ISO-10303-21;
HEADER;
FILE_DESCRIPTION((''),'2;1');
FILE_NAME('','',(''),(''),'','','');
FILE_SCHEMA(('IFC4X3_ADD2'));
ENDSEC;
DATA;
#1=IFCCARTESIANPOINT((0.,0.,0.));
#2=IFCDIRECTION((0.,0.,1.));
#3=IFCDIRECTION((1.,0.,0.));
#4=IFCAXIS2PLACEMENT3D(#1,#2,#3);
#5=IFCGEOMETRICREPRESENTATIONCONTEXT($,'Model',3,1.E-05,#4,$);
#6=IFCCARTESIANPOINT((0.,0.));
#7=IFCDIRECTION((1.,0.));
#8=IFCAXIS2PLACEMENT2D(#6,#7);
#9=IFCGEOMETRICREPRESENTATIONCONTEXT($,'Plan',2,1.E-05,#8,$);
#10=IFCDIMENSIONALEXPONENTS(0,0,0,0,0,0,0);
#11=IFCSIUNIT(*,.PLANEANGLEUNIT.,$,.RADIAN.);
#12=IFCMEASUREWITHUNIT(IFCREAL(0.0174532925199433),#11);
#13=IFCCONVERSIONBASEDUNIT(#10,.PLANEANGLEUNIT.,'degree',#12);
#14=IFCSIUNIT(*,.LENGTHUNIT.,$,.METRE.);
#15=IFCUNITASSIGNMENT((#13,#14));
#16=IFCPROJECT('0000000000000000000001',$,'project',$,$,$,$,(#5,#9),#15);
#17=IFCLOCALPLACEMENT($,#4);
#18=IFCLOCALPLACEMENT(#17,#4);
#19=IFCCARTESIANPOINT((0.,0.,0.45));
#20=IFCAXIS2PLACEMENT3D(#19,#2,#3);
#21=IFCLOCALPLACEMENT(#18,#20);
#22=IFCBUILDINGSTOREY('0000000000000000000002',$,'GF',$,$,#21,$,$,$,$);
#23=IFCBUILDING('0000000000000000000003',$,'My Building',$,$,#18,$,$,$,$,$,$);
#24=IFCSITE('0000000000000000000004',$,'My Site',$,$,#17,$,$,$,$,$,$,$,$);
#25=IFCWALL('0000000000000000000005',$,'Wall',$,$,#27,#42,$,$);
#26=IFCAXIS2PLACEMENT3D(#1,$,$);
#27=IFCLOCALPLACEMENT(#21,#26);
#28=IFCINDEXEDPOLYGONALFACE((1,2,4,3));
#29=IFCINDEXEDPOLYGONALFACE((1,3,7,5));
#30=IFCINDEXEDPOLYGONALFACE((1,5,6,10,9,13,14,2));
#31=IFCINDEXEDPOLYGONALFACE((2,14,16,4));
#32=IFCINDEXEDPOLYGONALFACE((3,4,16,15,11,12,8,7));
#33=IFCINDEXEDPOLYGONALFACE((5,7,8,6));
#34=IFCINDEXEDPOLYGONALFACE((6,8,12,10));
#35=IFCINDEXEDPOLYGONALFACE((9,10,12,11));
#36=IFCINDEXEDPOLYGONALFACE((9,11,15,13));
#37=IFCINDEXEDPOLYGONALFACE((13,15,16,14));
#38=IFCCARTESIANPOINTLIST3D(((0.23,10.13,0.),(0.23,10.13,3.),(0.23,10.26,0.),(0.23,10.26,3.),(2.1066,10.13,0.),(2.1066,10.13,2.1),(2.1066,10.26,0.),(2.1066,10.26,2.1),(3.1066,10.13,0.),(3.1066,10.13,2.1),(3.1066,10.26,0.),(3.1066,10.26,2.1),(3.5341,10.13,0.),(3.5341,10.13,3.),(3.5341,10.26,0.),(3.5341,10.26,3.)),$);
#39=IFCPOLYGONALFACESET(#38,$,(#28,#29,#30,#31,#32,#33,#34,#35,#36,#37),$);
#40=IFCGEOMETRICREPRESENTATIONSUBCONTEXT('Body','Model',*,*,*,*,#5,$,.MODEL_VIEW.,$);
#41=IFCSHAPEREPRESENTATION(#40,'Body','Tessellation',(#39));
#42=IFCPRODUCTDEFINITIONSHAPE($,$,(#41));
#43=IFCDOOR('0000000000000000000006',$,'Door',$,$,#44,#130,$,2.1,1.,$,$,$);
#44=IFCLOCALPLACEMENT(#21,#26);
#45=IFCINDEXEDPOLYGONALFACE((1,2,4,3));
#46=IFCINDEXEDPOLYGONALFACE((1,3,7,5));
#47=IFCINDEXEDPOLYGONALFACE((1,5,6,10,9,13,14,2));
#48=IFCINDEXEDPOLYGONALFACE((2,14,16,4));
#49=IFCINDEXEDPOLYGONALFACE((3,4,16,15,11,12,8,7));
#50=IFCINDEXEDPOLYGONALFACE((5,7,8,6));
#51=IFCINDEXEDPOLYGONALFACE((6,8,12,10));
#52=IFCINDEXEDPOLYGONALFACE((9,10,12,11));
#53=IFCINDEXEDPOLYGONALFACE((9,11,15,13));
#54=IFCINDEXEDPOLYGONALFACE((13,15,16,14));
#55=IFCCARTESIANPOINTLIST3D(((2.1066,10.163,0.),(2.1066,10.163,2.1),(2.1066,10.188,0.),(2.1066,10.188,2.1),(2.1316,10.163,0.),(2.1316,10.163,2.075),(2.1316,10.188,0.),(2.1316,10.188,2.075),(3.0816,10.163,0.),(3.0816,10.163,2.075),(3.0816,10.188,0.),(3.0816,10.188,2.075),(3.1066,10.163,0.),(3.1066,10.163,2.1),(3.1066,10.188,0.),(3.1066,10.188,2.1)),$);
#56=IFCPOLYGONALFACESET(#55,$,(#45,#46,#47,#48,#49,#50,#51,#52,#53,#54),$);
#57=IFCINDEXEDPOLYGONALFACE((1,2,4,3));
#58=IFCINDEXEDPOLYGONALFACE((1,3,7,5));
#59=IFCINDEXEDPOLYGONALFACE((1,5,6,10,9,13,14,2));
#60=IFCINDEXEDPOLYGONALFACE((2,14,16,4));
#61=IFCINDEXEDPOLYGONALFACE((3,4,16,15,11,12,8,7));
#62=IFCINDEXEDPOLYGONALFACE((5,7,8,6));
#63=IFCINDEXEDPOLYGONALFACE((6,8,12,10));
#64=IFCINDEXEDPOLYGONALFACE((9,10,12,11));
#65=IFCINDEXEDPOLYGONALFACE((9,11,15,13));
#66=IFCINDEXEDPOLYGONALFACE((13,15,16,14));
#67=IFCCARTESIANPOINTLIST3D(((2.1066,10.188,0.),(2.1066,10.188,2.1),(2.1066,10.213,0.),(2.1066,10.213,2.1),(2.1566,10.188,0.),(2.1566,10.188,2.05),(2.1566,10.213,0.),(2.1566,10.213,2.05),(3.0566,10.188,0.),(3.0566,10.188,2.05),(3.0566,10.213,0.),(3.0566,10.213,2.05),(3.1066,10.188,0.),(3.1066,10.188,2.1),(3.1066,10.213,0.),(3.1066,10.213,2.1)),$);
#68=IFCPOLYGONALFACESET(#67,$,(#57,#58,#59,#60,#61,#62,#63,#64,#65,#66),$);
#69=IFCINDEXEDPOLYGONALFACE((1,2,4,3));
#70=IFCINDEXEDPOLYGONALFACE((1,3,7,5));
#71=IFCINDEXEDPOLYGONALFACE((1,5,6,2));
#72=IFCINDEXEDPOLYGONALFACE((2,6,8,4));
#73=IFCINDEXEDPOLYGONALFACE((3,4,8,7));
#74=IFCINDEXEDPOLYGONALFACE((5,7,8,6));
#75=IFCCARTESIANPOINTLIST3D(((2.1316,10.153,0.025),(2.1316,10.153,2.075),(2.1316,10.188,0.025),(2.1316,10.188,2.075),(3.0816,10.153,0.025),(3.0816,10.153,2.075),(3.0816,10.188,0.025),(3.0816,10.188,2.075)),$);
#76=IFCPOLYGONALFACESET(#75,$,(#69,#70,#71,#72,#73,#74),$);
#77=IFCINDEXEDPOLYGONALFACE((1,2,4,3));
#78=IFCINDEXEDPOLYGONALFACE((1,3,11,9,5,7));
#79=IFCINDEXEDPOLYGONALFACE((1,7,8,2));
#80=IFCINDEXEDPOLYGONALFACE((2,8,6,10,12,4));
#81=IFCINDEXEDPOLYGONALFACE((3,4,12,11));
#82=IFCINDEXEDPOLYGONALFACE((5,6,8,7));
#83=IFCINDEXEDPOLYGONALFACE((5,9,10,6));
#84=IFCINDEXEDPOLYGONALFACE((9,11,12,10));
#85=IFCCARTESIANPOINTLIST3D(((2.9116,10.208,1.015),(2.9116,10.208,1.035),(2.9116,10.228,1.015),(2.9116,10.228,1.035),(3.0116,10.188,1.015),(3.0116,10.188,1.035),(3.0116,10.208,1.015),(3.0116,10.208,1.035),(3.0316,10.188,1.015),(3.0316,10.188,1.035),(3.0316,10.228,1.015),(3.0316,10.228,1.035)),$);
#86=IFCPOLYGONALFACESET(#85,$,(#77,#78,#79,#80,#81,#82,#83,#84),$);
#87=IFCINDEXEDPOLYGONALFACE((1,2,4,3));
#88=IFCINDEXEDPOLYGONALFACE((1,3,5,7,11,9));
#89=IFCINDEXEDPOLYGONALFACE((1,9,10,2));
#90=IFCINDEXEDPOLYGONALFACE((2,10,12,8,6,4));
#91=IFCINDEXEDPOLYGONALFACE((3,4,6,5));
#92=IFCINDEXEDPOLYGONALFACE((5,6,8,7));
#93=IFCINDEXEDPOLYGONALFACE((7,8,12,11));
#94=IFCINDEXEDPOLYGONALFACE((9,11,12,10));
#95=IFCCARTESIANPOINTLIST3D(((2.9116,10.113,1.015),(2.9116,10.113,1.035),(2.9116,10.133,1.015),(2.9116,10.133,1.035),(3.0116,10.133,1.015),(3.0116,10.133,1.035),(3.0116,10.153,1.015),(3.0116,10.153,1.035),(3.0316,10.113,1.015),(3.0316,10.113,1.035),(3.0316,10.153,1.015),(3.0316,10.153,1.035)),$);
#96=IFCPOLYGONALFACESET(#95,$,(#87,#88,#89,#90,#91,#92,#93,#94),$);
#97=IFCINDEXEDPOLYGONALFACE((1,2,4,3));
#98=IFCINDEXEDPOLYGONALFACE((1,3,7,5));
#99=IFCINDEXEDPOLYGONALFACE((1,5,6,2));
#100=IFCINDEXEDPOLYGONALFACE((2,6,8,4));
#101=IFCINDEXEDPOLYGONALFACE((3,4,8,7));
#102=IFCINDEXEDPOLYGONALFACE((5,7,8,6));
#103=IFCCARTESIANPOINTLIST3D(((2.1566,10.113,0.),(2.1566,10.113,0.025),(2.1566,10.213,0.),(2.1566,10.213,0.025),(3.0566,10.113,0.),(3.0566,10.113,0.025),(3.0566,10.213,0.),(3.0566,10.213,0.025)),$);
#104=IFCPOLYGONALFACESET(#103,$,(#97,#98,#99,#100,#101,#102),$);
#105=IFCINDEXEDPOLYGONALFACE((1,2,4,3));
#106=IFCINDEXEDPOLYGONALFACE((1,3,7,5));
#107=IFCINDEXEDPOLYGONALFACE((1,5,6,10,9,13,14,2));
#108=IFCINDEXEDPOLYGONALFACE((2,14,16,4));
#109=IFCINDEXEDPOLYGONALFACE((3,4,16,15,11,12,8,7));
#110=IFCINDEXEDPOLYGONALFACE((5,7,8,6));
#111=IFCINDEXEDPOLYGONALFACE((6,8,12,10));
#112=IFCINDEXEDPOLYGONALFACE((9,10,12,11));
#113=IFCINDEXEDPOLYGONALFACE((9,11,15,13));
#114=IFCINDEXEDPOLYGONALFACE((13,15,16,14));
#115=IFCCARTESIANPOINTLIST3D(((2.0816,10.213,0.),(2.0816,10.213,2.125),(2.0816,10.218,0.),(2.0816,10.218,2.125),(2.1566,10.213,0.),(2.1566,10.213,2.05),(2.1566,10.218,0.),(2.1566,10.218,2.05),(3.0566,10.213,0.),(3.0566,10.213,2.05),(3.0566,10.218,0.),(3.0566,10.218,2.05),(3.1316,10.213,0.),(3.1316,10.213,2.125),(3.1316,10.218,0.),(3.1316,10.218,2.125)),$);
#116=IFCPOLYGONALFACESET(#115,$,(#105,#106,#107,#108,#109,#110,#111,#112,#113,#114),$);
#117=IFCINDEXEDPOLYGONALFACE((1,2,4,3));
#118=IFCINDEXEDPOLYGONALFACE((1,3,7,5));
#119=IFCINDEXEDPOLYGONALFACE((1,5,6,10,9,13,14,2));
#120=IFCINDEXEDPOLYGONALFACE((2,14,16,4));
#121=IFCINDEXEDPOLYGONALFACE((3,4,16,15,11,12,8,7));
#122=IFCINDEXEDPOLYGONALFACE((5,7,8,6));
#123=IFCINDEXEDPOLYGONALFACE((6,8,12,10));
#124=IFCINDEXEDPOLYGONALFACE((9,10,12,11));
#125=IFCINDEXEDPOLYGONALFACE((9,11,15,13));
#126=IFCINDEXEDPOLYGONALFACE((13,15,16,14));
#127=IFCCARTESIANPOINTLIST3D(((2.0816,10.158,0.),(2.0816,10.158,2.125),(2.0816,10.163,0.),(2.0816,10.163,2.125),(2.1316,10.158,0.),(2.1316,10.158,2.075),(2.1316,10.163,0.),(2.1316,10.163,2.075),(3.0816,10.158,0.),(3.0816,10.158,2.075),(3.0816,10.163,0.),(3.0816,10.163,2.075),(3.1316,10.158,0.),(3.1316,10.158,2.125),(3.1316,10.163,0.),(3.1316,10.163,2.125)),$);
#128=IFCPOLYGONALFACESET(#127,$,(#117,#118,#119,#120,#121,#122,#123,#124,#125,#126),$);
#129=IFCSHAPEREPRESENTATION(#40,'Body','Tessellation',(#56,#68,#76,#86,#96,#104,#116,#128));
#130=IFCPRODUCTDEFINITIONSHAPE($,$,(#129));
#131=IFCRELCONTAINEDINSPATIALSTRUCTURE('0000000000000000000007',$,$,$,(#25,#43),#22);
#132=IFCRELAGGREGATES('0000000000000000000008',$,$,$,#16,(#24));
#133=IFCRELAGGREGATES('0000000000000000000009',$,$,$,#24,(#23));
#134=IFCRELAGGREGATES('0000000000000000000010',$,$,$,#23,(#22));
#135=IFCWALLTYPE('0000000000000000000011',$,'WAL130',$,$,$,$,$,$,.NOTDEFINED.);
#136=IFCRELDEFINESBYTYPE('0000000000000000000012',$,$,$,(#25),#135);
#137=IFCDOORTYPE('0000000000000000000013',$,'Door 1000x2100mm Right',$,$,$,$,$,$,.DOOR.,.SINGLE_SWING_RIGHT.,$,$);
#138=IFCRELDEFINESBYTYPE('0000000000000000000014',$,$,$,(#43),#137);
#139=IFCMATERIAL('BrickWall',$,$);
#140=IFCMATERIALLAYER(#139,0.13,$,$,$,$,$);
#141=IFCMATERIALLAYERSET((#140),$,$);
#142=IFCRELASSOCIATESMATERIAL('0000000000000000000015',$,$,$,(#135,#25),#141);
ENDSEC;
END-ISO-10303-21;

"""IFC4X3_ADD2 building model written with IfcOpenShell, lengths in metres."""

from ifc_helpers import new_model, entity, si_unit, converted_unit, frame, origin_with_axes, origin_2d_with_axis, place, context, subcontext, project, spatial, line, indexed_curve, outline, extrude, shape, source, transform, mapped, material, layer, layer_set, layer_usage, type_object, type_shapes, element, fill, save


model = new_model("IFC4X3_ADD2")

# Units and contexts
model_context = context("Model", 3, precision=1e-05, world=origin_with_axes())
plan_context = context("Plan", 2, precision=1e-05, world=origin_2d_with_axis())
body_context_1 = subcontext(model_context, "Body", "Model", "MODEL_VIEW")
body_context_2 = subcontext(plan_context, "Body", "Plan", "PLAN_VIEW")
ifc_project = project(units=[converted_unit("PLANEANGLEUNIT", "degree", entity("IfcReal", 0.0174532925199433), si_unit("PLANEANGLEUNIT", "RADIAN"), dimensions=[0, 0, 0, 0, 0, 0, 0]), si_unit("LENGTHUNIT", "METRE")], contexts=[model_context, plan_context])

# Site, building, storey
site_placement = place(None, origin_with_axes())
site = spatial("IfcSite", under=ifc_project, at=site_placement, Name="My Site")
building_placement = place(site_placement, origin_with_axes())
building = spatial("IfcBuilding", under=site, at=building_placement, Name="My Building")
storey_placement = place(building_placement, frame((0.0, 0.0, 0.45), z_axis=(0.0, 0.0, 1.0), x_axis=(1.0, 0.0, 0.0)))
storey = spatial("IfcBuildingStorey", under=building, at=storey_placement, Name="GF")

# Shared definitions
ifc_material = material(Name="BrickWall")

# Wall, opening, door
ifc_layer_1 = layer(ifc_material, 0.13)
ifc_layer_set_1 = layer_set([ifc_layer_1])
ifc_layer_usage_1 = layer_usage(ifc_layer_set_1, "AXIS2", "POSITIVE", 0.0)
wall_type_1 = type_object("IfcWallType", Name="WAL130", PredefinedType="NOTDEFINED", material=ifc_layer_set_1)
wall_1_placement = place(storey_placement, frame((0.23, 10.13, 0.0), z_axis=(0.0, 0.0, 1.0), x_axis=(1.0, 0.0, 0.0)))
wall_1 = element("IfcWall", 1, at=wall_1_placement, inside=storey, type_object=wall_type_1, material=ifc_layer_usage_1, Name="Wall", context=body_context_1, shape_type="SweptSolid", body=[
    extrude(outline(indexed_curve([(0.0, 0.0), (0.0, 0.13), (3.3041, 0.13), (3.3041, 0.0), (0.0, 0.0)], self_intersect=False)), origin_with_axes(), (0.0, 0.0, 1.0), 3.0),
])
shared_shape_1 = source(origin_with_axes(), body_context_1, "Body", "SweptSolid", [
    extrude(outline(indexed_curve([(0.0, 0.0), (1.0, 0.0), (1.0, 2.1), (0.0, 2.1)], segments=[line(1, 2, 3, 4, 1)])), frame((0.0, -0.6, 0.0), z_axis=(0.0, -1.0, 0.0), x_axis=(1.0, 0.0, 0.0)), (0.0, 0.0, -1.0), 1.2),
])
opening_1_placement = place(wall_1_placement, frame((2.8766, 0.083, 0.0), z_axis=(0.0, 0.0, 1.0), x_axis=(-1.0, 0.0, 0.0)))
opening_1 = element("IfcOpeningElement", 2, at=opening_1_placement, cuts=wall_1, PredefinedType="OPENING", context=body_context_1, shape_type="MappedRepresentation", body=[
    mapped(shared_shape_1, transform((0.0, 0.0, 0.0), x_axis=(1.0, 0.0, 0.0), y_axis=(0.0, 1.0, 0.0), z_axis=(0.0, 0.0, 1.0), scale=1.0)),
])
door_type_1 = type_object("IfcDoorType", Name="Door 1000x2100mm Right", OperationType="SINGLE_SWING_RIGHT", PredefinedType="DOOR")
shared_shape_2 = source(origin_with_axes(), body_context_1, "Body", "SweptSolid", [
    extrude(outline(indexed_curve([(0.0, 0.0), (0.0, 2.1), (1.0, 2.1), (1.0, 0.0), (0.975, 0.0), (0.975, 2.075), (0.025, 2.075), (0.025, 0.0)], segments=[line(1, 2, 3, 4, 5, 6, 7, 8, 1)])), frame((0.0, 0.025, 0.0), z_axis=(0.0, -1.0, 0.0), x_axis=(1.0, 0.0, 0.0)), (0.0, 0.0, -1.0), 0.025),
    extrude(outline(indexed_curve([(0.0, 0.0), (0.0, 2.1), (1.0, 2.1), (1.0, 0.0), (0.95, 0.0), (0.95, 2.05), (0.05, 2.05), (0.05, 0.0)], segments=[line(1, 2, 3, 4, 5, 6, 7, 8, 1)])), frame((0.0, 0.0, 0.0), z_axis=(0.0, -1.0, 0.0), x_axis=(1.0, 0.0, 0.0)), (0.0, 0.0, -1.0), 0.025),
    extrude(outline(indexed_curve([(0.0, 0.0), (0.95, 0.0), (0.95, 0.035), (0.0, 0.035)], segments=[line(1, 2, 3, 4, 1)])), frame((0.025, 0.025, 0.025), z_axis=(0.0, 0.0, 1.0), x_axis=(1.0, 0.0, 0.0)), (0.0, 0.0, 1.0), 2.05),
    extrude(outline(indexed_curve([(0.0, 0.0), (0.0, -0.04), (0.12, -0.04), (0.12, -0.02), (0.02, -0.02), (0.02, 0.0)], segments=[line(1, 2, 3, 4, 5, 6, 1)])), frame((0.075, 0.025, 1.015), z_axis=(0.0, 0.0, 1.0), x_axis=(1.0, 0.0, 0.0)), (0.0, 0.0, 1.0), 0.02),
    extrude(outline(indexed_curve([(0.0, 0.0), (0.0, 0.04), (0.12, 0.04), (0.12, 0.02), (0.02, 0.02), (0.02, 0.0)], segments=[line(1, 2, 3, 4, 5, 6, 1)])), frame((0.075, 0.06, 1.015), z_axis=(0.0, 0.0, 1.0), x_axis=(1.0, 0.0, 0.0)), (0.0, 0.0, 1.0), 0.02),
    extrude(outline(indexed_curve([(0.0, 0.0), (0.9, 0.0), (0.9, 0.1), (0.0, 0.1)], segments=[line(1, 2, 3, 4, 1)])), frame((0.05, 0.0, 0.0), z_axis=(0.0, 0.0, 1.0), x_axis=(1.0, 0.0, 0.0)), (0.0, 0.0, 1.0), 0.025),
    extrude(outline(indexed_curve([(0.0, 0.0), (0.0, 2.125), (1.05, 2.125), (1.05, 0.0), (0.975, 0.0), (0.975, 2.05), (0.075, 2.05), (0.075, 0.0)], segments=[line(1, 2, 3, 4, 5, 6, 7, 8, 1)])), frame((-0.025, -0.005, 0.0), z_axis=(0.0, -1.0, 0.0), x_axis=(1.0, 0.0, 0.0)), (0.0, 0.0, -1.0), 0.005),
    extrude(outline(indexed_curve([(0.0, 0.0), (0.0, 2.125), (1.05, 2.125), (1.05, 0.0), (1.0, 0.0), (1.0, 2.075), (0.05, 2.075), (0.05, 0.0)], segments=[line(1, 2, 3, 4, 5, 6, 7, 8, 1)])), frame((-0.025, 0.05, 0.0), z_axis=(0.0, -1.0, 0.0), x_axis=(1.0, 0.0, 0.0)), (0.0, 0.0, -1.0), 0.005),
])
shared_shape_3 = source(origin_with_axes(), body_context_2, "Body", "Curve2D", [
    entity("IfcIndexedPolyCurve", entity("IfcCartesianPointList2D", [[0.0, 0.0], [0.0, 0.05], [0.025, 0.05], [0.025, 0.025], [0.05, 0.025], [0.05, 0.0]]), [entity("IfcLineIndex", [1, 2, 3, 4, 5, 6, 1])]),
    entity("IfcIndexedPolyCurve", entity("IfcCartesianPointList2D", [[1.0, 0.0], [1.0, 0.05], [0.975, 0.05], [0.975, 0.025], [0.95, 0.025], [0.95, 0.0]]), [entity("IfcLineIndex", [1, 2, 3, 4, 5, 6, 1])]),
    entity("IfcTrimmedCurve", entity("IfcEllipse", entity("IfcAxis2Placement2D", entity("IfcCartesianPoint", [0.94, 0.05]), entity("IfcDirection", [1.0, 0.0])), 0.915, 0.95), [entity("IfcCartesianPoint", [0.94, 1.0])], [entity("IfcCartesianPoint", [0.025, 0.05])], True, "CARTESIAN"),
    entity("IfcIndexedPolyCurve", entity("IfcCartesianPointList2D", [[0.975, 0.05], [0.94, 0.05], [0.94, 1.0], [0.975, 1.0]]), [entity("IfcLineIndex", [1, 2, 3, 4, 1])]),
])
type_shapes(door_type_1, [shared_shape_2, shared_shape_3])
door_1_placement = place(opening_1_placement, frame((0.0, 0.0, 0.0), z_axis=(0.0, 0.0, 1.0), x_axis=(1.0, 0.0, 0.0)))
door_1 = element("IfcDoor", 3, at=door_1_placement, inside=storey, type_object=door_type_1, Name="Door", OverallHeight=2.1, OverallWidth=1.0, shapes=[
    shape(body_context_1, "Body", "MappedRepresentation", [mapped(shared_shape_2, transform((0.0, 0.0, 0.0), x_axis=(1.0, 0.0, 0.0), y_axis=(0.0, 1.0, 0.0), z_axis=(0.0, 0.0, 1.0), scale=1.0))]),
    shape(body_context_2, "Body", "MappedRepresentation", [mapped(shared_shape_3, transform((0.0, 0.0, 0.0), x_axis=(1.0, 0.0, 0.0), y_axis=(0.0, 1.0, 0.0), z_axis=(0.0, 0.0, 1.0), scale=1.0))]),
])
fill(opening_1, door_1)

save(model, "model.ifc")
